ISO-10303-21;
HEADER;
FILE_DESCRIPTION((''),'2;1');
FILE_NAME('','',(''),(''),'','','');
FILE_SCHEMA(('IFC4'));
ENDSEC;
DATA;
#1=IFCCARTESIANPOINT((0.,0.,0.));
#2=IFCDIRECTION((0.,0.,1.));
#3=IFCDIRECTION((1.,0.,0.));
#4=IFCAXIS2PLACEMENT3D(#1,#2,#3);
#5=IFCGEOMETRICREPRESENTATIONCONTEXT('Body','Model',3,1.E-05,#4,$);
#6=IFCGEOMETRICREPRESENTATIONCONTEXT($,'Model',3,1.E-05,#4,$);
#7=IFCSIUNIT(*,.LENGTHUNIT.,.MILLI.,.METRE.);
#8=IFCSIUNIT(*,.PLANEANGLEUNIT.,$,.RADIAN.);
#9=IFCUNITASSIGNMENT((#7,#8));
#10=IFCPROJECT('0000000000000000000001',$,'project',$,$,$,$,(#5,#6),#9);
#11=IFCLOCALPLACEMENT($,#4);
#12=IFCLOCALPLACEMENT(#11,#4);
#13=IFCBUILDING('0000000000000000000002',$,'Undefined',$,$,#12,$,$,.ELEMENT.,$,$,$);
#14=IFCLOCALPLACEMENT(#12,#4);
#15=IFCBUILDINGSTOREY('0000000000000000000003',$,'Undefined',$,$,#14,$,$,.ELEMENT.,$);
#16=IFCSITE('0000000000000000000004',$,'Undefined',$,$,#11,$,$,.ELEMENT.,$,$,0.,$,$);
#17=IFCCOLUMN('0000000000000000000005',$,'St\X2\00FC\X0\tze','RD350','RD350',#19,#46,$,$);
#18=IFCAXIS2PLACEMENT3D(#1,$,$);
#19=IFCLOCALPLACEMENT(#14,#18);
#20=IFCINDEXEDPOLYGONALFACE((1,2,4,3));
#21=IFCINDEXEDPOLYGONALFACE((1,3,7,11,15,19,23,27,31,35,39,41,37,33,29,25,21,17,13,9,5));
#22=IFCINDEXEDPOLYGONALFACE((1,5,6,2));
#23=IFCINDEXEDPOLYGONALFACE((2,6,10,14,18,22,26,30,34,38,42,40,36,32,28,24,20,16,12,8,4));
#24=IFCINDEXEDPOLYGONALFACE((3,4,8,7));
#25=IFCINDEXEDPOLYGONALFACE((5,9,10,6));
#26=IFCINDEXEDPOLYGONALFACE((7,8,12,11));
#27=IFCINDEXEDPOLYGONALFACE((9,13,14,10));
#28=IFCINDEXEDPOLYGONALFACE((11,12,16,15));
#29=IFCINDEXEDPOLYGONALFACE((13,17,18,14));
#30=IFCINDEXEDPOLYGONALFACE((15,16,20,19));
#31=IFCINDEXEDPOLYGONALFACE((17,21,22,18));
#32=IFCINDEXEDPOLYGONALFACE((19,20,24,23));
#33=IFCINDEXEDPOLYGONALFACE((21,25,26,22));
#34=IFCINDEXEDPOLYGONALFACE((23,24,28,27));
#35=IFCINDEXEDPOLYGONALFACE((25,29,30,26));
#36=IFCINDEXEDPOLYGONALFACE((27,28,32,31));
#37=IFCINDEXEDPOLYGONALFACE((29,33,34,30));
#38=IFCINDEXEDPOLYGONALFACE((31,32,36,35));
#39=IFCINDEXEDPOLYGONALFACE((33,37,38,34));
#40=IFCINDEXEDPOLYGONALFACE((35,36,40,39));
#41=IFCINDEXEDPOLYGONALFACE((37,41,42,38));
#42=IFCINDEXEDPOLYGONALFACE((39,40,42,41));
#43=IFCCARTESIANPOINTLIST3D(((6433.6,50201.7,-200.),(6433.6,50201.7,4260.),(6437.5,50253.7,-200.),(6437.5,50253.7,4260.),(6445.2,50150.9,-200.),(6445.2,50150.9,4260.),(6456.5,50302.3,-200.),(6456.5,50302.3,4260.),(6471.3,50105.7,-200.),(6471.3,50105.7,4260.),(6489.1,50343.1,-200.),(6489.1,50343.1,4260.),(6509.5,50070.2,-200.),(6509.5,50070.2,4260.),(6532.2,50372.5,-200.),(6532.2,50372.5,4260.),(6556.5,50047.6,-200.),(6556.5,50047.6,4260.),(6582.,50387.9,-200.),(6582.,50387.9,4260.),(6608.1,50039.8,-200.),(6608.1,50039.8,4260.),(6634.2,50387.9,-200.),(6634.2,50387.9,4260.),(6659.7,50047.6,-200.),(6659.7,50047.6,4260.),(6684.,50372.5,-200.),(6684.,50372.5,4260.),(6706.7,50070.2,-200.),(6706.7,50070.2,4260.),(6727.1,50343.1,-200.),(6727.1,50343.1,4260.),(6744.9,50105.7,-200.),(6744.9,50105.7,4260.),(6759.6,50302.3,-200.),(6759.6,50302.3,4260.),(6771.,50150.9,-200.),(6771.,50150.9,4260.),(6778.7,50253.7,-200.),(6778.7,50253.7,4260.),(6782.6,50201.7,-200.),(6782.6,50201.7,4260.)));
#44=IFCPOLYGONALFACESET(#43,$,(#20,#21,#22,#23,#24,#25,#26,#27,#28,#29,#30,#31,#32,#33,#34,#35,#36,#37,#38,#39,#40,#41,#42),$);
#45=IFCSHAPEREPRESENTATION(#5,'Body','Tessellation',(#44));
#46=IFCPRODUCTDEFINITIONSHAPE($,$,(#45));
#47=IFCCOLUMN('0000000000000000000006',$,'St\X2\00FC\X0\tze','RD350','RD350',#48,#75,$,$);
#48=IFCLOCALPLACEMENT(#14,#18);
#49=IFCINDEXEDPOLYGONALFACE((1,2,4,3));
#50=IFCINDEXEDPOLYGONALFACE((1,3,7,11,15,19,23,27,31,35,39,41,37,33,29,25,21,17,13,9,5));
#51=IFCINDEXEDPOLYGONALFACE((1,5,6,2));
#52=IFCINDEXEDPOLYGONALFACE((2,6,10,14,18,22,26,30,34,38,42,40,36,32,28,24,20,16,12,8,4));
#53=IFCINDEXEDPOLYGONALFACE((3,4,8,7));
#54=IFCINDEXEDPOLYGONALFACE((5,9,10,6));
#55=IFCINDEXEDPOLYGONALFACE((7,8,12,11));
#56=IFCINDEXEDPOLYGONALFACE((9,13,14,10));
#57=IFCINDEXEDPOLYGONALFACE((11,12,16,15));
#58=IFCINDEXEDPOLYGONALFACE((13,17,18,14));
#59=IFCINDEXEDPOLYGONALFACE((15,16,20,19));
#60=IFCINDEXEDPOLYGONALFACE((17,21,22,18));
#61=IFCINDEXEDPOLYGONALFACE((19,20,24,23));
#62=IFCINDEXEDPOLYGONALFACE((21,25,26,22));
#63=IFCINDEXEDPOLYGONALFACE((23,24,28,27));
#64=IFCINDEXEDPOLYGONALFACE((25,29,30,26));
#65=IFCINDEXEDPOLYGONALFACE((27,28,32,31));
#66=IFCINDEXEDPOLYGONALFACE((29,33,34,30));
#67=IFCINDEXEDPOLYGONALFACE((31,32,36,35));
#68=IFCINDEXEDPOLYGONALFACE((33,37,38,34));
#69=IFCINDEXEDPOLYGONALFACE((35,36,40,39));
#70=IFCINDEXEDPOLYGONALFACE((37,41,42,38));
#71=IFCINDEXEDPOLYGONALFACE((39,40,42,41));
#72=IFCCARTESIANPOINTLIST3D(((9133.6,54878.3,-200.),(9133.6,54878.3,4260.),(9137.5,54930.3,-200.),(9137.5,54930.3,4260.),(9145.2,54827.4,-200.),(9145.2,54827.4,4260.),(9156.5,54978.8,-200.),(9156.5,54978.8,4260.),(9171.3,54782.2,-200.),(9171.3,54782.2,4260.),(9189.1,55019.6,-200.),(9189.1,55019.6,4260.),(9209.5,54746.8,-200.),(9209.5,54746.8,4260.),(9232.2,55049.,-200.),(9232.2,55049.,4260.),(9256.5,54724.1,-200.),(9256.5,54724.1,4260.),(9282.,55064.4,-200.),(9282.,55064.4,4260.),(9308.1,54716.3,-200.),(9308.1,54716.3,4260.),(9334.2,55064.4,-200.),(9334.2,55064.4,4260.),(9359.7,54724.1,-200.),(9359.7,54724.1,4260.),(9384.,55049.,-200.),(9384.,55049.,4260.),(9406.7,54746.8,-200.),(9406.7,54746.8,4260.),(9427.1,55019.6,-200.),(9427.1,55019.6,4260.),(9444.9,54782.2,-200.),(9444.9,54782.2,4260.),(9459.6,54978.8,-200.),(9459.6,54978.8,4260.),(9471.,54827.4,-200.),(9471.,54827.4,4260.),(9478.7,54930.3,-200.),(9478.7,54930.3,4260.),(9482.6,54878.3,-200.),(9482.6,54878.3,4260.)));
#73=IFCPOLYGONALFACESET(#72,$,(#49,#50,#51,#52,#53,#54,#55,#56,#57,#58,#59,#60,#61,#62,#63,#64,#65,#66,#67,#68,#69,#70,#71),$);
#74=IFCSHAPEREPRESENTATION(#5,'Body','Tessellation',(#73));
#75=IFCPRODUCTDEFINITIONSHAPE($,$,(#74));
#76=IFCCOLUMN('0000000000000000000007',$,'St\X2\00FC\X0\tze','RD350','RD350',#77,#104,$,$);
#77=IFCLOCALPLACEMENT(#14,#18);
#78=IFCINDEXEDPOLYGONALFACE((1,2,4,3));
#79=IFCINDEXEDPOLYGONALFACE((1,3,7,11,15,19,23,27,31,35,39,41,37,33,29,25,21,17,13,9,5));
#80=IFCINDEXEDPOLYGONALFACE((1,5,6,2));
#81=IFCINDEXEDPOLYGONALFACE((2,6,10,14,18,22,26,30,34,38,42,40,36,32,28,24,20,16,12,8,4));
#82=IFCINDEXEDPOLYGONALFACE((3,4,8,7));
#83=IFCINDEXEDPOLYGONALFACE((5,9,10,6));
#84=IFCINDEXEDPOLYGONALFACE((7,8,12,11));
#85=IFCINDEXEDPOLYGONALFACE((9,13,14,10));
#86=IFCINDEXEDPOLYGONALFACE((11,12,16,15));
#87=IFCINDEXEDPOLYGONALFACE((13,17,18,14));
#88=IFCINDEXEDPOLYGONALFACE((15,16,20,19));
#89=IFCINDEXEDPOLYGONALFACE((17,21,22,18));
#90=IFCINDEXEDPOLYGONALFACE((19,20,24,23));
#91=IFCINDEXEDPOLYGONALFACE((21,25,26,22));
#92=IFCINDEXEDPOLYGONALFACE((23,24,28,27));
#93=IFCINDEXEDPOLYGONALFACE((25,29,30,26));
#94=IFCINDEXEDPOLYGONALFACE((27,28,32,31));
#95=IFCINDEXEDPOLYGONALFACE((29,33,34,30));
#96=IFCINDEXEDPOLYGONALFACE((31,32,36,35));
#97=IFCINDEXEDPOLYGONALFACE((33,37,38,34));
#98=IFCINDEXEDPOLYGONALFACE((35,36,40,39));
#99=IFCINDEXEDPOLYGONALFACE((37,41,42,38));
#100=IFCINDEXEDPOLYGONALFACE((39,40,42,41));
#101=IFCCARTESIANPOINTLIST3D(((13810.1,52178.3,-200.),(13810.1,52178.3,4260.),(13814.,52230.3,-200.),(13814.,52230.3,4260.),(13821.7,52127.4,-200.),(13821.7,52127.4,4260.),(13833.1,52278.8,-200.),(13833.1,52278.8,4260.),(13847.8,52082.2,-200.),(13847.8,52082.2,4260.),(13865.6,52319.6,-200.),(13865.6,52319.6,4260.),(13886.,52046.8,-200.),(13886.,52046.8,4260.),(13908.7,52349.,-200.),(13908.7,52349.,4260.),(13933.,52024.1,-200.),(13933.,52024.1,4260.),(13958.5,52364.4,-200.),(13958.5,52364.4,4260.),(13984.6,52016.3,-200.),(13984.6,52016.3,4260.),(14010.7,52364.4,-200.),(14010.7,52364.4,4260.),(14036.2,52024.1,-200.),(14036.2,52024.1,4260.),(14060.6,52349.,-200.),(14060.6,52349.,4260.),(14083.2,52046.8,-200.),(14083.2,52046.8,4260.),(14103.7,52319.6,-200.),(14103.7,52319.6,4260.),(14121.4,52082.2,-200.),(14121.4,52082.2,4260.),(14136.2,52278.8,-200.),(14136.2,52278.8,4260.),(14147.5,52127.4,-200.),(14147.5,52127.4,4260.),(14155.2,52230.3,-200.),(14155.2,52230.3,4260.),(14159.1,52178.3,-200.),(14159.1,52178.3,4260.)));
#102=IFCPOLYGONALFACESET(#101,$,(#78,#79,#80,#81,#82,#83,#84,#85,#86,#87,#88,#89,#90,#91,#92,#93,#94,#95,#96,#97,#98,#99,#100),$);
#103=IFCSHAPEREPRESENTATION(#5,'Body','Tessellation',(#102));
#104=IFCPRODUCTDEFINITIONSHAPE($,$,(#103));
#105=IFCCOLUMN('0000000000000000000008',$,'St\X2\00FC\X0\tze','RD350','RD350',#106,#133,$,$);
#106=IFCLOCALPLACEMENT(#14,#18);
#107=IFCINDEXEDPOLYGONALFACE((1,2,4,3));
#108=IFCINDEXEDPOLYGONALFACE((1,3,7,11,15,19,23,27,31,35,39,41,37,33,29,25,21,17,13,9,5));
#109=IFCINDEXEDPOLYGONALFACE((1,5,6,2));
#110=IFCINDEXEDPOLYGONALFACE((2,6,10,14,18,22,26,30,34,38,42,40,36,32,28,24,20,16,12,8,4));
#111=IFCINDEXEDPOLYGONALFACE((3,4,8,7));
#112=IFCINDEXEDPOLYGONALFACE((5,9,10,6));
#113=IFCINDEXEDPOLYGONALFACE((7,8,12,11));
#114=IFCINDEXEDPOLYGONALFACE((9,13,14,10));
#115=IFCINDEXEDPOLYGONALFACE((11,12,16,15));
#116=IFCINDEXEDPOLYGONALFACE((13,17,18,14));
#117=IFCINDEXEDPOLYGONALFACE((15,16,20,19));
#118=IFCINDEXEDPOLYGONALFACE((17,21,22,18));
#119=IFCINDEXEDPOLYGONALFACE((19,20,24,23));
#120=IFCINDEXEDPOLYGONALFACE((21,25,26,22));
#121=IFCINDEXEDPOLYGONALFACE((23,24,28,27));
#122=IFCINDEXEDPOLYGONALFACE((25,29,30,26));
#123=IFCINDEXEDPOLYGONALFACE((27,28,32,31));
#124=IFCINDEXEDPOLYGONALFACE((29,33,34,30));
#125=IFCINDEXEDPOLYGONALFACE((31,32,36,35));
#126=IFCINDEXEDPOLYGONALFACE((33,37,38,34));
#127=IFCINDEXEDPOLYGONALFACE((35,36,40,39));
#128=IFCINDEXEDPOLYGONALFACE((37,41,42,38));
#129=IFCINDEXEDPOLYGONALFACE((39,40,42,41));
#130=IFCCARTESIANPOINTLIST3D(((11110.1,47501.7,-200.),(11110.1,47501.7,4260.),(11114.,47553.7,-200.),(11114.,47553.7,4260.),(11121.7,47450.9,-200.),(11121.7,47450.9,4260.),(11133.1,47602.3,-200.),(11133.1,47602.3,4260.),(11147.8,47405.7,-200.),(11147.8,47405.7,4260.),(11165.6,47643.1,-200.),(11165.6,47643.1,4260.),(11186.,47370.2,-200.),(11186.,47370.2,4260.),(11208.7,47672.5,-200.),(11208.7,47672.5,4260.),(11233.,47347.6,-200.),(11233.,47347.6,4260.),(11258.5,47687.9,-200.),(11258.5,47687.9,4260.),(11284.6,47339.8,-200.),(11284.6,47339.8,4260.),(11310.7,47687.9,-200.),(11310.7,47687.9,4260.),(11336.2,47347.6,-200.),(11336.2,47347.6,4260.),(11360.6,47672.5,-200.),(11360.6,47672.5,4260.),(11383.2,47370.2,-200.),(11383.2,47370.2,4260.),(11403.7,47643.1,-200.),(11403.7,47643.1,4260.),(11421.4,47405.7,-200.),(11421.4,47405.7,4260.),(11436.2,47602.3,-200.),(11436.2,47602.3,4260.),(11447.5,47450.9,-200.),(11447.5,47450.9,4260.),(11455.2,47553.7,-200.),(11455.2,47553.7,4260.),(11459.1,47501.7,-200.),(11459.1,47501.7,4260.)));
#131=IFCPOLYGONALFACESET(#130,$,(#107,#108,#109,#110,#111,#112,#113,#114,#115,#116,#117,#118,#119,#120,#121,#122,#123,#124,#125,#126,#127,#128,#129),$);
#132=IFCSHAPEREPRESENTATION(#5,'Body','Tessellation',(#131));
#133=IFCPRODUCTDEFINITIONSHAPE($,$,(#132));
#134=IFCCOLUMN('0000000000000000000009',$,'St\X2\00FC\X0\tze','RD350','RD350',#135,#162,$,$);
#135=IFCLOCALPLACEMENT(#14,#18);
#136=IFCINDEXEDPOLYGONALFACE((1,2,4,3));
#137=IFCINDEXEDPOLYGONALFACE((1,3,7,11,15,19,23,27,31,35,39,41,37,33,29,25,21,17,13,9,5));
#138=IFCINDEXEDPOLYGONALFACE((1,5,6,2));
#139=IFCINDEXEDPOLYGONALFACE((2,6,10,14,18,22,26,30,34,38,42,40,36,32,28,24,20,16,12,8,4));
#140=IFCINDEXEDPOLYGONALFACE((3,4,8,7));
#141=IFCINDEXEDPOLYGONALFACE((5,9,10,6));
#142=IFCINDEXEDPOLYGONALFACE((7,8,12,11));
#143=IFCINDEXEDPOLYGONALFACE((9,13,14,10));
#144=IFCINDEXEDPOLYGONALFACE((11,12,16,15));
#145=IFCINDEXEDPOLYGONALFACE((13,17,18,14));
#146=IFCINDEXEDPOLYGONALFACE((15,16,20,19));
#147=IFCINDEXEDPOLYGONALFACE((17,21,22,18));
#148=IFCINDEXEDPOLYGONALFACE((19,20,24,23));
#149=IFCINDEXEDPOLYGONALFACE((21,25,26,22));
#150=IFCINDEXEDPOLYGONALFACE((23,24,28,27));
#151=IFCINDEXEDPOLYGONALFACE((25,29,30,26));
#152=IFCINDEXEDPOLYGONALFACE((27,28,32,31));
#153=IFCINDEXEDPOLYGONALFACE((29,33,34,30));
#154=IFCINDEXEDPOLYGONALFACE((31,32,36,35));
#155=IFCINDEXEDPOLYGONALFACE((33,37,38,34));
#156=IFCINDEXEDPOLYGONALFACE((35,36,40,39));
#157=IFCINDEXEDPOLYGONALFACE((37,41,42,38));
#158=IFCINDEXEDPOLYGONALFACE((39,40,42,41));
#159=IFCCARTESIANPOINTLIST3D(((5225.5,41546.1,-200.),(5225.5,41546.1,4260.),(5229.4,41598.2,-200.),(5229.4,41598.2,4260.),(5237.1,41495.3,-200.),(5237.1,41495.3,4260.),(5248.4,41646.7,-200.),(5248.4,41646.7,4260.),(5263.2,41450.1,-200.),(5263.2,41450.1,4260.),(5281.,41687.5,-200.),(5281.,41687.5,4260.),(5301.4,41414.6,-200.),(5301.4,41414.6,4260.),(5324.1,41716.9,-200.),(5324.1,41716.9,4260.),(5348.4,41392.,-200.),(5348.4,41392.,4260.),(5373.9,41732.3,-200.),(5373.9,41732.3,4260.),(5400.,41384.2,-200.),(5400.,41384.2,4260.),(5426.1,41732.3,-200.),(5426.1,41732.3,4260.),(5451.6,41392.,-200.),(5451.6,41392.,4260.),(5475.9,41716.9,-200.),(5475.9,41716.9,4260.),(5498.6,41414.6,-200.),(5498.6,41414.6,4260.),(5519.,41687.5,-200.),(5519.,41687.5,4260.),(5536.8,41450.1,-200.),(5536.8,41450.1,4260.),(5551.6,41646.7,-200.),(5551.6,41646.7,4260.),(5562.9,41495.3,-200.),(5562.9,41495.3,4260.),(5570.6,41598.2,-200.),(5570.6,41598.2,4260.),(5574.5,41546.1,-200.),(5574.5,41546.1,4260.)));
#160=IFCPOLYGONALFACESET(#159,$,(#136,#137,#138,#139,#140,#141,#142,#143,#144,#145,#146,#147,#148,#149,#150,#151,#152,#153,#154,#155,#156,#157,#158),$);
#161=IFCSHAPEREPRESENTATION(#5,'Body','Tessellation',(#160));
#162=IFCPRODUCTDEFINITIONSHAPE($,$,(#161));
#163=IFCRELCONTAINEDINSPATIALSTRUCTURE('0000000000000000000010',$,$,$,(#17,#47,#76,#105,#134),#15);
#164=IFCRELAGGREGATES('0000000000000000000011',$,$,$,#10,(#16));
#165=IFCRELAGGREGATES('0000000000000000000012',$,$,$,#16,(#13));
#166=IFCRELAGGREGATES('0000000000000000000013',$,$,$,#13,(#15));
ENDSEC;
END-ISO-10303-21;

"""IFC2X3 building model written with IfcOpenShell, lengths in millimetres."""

from ifc_helpers import new_model, si_unit, frame, origin_with_axes, origin_2d_with_axis, place, context, project, spatial, circle, extrude, element, save


model = new_model("IFC2X3")

# Units and contexts
model_context_1 = context("Model", 3, precision=1e-05, world=origin_with_axes(), identifier="Body")
model_context_2 = context("Model", 3, precision=1e-05, world=origin_with_axes())
ifc_project = project(units=[si_unit("LENGTHUNIT", "METRE", prefix="MILLI"), si_unit("PLANEANGLEUNIT", "RADIAN")], contexts=[model_context_1, model_context_2])

# Site, building, storey
site_placement = place(None, origin_with_axes())
site = spatial("IfcSite", under=ifc_project, at=site_placement, Name="Undefined", CompositionType="ELEMENT", RefElevation=0.0)
building_placement = place(site_placement, origin_with_axes())
building = spatial("IfcBuilding", under=site, at=building_placement, Name="Undefined", CompositionType="ELEMENT")
storey_placement = place(building_placement, origin_with_axes())
storey = spatial("IfcBuildingStorey", under=building, at=storey_placement, Name="Undefined", CompositionType="ELEMENT")

# Columns
for number, where, z_axis, x_axis, name in (
    (1, (6608.1, 50214.8, -200.0), (0.0, 0.0, 1.0), (1.0, 0.0, 0.0), "Stütze"),
    (2, (9308.1, 54891.3, -200.0), (0.0, 0.0, 1.0), (1.0, 0.0, 0.0), "Stütze"),
    (3, (13984.6, 52191.3, -200.0), (0.0, 0.0, 1.0), (1.0, 0.0, 0.0), "Stütze"),
    (4, (11284.6, 47514.8, -200.0), (0.0, 0.0, 1.0), (1.0, 0.0, 0.0), "Stütze"),
    (5, (5400.0, 41559.2, -200.0), (0.0, 0.0, 1.0), (1.0, 0.0, 0.0), "Stütze"),
):
    element("IfcColumn", number, at=place(storey_placement, frame(where, z_axis=z_axis, x_axis=x_axis)), inside=storey, Name=name, Description="RD350", ObjectType="RD350", context=model_context_1, shape_type="SweptSolid", body=[
        extrude(circle(Radius=175.0, at=origin_2d_with_axis()), frame((0.0, 0.0, 4460.0), z_axis=(0.0, 0.0, -1.0), x_axis=(-0.866025, 0.500001, 0.0)), (0.0, 0.0, 1.0), 4460.0),
    ])

save(model, "model.ifc")
